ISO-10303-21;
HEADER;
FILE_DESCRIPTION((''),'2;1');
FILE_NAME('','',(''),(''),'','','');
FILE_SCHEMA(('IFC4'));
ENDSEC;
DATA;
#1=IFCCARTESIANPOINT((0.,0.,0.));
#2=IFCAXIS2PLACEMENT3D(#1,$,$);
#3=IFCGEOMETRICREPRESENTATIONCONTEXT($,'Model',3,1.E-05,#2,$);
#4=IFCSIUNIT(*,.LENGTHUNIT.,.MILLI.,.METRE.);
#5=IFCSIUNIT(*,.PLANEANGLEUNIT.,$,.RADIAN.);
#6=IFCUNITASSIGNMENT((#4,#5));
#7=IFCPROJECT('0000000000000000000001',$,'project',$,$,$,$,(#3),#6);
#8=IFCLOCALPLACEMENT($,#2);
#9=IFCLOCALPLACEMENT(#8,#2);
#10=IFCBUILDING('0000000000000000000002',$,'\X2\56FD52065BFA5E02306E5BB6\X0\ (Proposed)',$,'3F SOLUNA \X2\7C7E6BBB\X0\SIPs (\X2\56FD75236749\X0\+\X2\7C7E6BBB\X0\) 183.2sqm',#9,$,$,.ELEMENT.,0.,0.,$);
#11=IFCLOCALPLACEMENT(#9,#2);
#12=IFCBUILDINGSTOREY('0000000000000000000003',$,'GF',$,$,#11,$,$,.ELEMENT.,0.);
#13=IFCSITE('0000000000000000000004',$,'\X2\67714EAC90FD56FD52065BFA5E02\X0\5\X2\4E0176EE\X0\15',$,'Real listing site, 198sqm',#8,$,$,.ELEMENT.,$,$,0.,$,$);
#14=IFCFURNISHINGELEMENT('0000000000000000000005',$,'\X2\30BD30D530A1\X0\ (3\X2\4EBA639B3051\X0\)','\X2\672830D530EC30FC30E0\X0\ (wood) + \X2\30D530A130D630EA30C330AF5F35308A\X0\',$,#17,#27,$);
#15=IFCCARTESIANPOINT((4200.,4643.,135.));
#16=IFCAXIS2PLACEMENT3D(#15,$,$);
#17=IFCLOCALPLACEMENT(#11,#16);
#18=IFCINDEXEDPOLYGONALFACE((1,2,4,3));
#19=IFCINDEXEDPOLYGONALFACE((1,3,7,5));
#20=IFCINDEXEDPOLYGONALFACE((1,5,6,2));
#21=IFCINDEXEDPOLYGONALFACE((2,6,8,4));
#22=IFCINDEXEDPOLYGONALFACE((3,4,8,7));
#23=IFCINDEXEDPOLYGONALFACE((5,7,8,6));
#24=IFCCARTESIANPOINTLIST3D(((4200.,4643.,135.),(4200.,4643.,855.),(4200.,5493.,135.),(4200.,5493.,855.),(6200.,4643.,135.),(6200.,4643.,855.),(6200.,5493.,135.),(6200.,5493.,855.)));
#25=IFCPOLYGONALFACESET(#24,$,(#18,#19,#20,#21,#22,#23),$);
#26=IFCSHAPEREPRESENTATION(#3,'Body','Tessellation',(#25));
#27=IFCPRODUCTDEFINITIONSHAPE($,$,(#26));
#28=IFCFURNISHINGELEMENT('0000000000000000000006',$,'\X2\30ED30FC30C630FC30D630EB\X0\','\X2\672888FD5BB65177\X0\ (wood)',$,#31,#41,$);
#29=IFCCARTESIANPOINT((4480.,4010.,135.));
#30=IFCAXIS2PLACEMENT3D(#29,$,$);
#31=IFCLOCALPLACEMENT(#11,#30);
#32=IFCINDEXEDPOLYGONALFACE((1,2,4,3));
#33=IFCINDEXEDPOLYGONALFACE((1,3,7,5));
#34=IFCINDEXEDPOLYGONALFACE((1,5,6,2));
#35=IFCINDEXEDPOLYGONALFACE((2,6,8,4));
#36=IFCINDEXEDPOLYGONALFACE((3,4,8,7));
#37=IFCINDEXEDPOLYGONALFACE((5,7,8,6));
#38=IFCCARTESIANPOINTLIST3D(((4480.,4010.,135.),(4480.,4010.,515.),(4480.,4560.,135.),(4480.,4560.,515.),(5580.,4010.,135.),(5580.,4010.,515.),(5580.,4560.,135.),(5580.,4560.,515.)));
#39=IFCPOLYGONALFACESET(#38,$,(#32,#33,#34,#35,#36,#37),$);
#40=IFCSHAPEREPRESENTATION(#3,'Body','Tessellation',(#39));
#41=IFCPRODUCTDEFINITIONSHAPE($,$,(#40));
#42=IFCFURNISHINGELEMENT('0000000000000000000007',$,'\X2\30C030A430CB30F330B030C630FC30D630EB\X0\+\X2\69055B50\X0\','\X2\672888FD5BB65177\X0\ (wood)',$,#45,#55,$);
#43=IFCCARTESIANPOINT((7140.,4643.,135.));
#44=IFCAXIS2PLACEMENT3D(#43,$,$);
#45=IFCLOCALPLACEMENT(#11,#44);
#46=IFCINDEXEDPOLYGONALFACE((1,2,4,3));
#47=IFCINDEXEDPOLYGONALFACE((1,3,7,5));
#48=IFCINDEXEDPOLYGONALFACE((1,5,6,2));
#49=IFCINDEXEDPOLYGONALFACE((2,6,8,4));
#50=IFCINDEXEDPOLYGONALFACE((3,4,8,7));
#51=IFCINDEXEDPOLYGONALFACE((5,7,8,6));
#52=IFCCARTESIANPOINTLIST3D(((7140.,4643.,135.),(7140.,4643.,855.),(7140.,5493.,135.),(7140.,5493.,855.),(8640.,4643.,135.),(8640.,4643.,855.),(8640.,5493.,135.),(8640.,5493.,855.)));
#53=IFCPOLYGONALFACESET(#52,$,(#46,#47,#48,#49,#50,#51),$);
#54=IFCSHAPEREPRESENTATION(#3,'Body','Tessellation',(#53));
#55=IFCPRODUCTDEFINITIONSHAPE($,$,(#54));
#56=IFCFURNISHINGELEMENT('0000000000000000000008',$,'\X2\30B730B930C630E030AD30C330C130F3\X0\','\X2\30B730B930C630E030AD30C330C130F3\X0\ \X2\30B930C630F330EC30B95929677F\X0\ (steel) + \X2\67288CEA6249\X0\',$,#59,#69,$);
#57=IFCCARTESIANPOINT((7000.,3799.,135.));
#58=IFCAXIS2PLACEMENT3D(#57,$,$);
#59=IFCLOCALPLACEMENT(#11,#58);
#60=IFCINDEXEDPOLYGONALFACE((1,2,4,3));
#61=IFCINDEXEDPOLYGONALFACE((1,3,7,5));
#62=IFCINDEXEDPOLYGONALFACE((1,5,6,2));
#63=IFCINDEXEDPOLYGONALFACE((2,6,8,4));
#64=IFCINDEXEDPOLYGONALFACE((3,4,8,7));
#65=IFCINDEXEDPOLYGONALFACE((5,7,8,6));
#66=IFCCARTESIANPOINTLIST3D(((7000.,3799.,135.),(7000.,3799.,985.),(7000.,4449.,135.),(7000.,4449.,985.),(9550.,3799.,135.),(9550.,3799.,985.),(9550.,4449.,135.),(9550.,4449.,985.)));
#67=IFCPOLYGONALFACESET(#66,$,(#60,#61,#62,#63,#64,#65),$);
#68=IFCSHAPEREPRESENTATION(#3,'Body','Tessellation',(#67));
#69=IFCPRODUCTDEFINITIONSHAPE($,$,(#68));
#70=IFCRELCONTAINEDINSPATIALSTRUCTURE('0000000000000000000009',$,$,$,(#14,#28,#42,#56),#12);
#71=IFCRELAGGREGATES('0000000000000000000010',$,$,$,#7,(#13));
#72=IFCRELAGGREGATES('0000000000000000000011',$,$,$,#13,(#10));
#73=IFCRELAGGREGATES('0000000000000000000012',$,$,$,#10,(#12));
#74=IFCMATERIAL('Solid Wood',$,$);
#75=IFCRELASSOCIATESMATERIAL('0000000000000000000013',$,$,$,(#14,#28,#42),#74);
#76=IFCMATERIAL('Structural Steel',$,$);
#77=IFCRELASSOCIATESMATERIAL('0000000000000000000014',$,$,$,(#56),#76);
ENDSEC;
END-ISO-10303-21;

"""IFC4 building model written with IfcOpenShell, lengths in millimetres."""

from ifc_helpers import new_model, si_unit, frame, frame_2d, origin, place, context, project, spatial, rectangle, extrude, material, element, save


model = new_model("IFC4")

# Units and contexts
model_context = context("Model", 3, precision=1e-05, world=origin())
ifc_project = project(units=[si_unit("LENGTHUNIT", "METRE", prefix="MILLI"), si_unit("PLANEANGLEUNIT", "RADIAN")], contexts=[model_context])

# Site, building, storey
site_placement = place(None, origin())
site = spatial("IfcSite", under=ifc_project, at=site_placement, Name="東京都国分寺市5丁目15", ObjectType="Real listing site, 198sqm", CompositionType="ELEMENT", RefElevation=0.0)
building_placement = place(site_placement, origin())
building = spatial("IfcBuilding", under=site, at=building_placement, Name="国分寺市の家 (Proposed)", ObjectType="3F SOLUNA 籾殻SIPs (国産杉+籾殻) 183.2sqm", CompositionType="ELEMENT", ElevationOfRefHeight=0.0, ElevationOfTerrain=0.0)
storey_placement = place(building_placement, origin())
storey = spatial("IfcBuildingStorey", under=building, at=storey_placement, Name="GF", CompositionType="ELEMENT", Elevation=0.0)

# Shared definitions
ifc_material_1 = material(Name="Solid Wood")

# Furnishing elements
furnishing_1_placement = place(storey_placement, frame((4200.0, 4643.0, 135.0)))
element("IfcFurnishingElement", 1, at=furnishing_1_placement, inside=storey, material=ifc_material_1, Name="ソファ (3人掛け)", Description="木フレーム (wood) + ファブリック張り", context=model_context, shape_type="SweptSolid", body=[
    extrude(rectangle(XDim=2000.0, YDim=850.0, at=frame_2d((1000.0, 425.0))), frame((4200.0, 4643.0, 135.0)), (0.0, 0.0, 1.0), 720.0),
])
furnishing_2_placement = place(storey_placement, frame((4480.0, 4010.0, 135.0)))
element("IfcFurnishingElement", 2, at=furnishing_2_placement, inside=storey, material=ifc_material_1, Name="ローテーブル", Description="木製家具 (wood)", context=model_context, shape_type="SweptSolid", body=[
    extrude(rectangle(XDim=1100.0, YDim=550.0, at=frame_2d((550.0, 275.0))), frame((4480.0, 4010.0, 135.0)), (0.0, 0.0, 1.0), 380.0),
])
furnishing_3_placement = place(storey_placement, frame((7140.0, 4643.0, 135.0)))
element("IfcFurnishingElement", 3, at=furnishing_3_placement, inside=storey, material=ifc_material_1, Name="ダイニングテーブル+椅子", Description="木製家具 (wood)", context=model_context, shape_type="SweptSolid", body=[
    extrude(rectangle(XDim=1500.0, YDim=850.0, at=frame_2d((750.0, 425.0))), frame((7140.0, 4643.0, 135.0)), (0.0, 0.0, 1.0), 720.0),
])
ifc_material_2 = material(Name="Structural Steel")
furnishing_4_placement = place(storey_placement, frame((7000.0, 3799.0, 135.0)))
element("IfcFurnishingElement", 4, at=furnishing_4_placement, inside=storey, material=ifc_material_2, Name="システムキッチン", Description="システムキッチン ステンレス天板 (steel) + 木質扉", context=model_context, shape_type="SweptSolid", body=[
    extrude(rectangle(XDim=2550.0, YDim=650.0, at=frame_2d((1275.0, 325.0))), frame((7000.0, 3799.0, 135.0)), (0.0, 0.0, 1.0), 850.0),
])

save(model, "model.ifc")
